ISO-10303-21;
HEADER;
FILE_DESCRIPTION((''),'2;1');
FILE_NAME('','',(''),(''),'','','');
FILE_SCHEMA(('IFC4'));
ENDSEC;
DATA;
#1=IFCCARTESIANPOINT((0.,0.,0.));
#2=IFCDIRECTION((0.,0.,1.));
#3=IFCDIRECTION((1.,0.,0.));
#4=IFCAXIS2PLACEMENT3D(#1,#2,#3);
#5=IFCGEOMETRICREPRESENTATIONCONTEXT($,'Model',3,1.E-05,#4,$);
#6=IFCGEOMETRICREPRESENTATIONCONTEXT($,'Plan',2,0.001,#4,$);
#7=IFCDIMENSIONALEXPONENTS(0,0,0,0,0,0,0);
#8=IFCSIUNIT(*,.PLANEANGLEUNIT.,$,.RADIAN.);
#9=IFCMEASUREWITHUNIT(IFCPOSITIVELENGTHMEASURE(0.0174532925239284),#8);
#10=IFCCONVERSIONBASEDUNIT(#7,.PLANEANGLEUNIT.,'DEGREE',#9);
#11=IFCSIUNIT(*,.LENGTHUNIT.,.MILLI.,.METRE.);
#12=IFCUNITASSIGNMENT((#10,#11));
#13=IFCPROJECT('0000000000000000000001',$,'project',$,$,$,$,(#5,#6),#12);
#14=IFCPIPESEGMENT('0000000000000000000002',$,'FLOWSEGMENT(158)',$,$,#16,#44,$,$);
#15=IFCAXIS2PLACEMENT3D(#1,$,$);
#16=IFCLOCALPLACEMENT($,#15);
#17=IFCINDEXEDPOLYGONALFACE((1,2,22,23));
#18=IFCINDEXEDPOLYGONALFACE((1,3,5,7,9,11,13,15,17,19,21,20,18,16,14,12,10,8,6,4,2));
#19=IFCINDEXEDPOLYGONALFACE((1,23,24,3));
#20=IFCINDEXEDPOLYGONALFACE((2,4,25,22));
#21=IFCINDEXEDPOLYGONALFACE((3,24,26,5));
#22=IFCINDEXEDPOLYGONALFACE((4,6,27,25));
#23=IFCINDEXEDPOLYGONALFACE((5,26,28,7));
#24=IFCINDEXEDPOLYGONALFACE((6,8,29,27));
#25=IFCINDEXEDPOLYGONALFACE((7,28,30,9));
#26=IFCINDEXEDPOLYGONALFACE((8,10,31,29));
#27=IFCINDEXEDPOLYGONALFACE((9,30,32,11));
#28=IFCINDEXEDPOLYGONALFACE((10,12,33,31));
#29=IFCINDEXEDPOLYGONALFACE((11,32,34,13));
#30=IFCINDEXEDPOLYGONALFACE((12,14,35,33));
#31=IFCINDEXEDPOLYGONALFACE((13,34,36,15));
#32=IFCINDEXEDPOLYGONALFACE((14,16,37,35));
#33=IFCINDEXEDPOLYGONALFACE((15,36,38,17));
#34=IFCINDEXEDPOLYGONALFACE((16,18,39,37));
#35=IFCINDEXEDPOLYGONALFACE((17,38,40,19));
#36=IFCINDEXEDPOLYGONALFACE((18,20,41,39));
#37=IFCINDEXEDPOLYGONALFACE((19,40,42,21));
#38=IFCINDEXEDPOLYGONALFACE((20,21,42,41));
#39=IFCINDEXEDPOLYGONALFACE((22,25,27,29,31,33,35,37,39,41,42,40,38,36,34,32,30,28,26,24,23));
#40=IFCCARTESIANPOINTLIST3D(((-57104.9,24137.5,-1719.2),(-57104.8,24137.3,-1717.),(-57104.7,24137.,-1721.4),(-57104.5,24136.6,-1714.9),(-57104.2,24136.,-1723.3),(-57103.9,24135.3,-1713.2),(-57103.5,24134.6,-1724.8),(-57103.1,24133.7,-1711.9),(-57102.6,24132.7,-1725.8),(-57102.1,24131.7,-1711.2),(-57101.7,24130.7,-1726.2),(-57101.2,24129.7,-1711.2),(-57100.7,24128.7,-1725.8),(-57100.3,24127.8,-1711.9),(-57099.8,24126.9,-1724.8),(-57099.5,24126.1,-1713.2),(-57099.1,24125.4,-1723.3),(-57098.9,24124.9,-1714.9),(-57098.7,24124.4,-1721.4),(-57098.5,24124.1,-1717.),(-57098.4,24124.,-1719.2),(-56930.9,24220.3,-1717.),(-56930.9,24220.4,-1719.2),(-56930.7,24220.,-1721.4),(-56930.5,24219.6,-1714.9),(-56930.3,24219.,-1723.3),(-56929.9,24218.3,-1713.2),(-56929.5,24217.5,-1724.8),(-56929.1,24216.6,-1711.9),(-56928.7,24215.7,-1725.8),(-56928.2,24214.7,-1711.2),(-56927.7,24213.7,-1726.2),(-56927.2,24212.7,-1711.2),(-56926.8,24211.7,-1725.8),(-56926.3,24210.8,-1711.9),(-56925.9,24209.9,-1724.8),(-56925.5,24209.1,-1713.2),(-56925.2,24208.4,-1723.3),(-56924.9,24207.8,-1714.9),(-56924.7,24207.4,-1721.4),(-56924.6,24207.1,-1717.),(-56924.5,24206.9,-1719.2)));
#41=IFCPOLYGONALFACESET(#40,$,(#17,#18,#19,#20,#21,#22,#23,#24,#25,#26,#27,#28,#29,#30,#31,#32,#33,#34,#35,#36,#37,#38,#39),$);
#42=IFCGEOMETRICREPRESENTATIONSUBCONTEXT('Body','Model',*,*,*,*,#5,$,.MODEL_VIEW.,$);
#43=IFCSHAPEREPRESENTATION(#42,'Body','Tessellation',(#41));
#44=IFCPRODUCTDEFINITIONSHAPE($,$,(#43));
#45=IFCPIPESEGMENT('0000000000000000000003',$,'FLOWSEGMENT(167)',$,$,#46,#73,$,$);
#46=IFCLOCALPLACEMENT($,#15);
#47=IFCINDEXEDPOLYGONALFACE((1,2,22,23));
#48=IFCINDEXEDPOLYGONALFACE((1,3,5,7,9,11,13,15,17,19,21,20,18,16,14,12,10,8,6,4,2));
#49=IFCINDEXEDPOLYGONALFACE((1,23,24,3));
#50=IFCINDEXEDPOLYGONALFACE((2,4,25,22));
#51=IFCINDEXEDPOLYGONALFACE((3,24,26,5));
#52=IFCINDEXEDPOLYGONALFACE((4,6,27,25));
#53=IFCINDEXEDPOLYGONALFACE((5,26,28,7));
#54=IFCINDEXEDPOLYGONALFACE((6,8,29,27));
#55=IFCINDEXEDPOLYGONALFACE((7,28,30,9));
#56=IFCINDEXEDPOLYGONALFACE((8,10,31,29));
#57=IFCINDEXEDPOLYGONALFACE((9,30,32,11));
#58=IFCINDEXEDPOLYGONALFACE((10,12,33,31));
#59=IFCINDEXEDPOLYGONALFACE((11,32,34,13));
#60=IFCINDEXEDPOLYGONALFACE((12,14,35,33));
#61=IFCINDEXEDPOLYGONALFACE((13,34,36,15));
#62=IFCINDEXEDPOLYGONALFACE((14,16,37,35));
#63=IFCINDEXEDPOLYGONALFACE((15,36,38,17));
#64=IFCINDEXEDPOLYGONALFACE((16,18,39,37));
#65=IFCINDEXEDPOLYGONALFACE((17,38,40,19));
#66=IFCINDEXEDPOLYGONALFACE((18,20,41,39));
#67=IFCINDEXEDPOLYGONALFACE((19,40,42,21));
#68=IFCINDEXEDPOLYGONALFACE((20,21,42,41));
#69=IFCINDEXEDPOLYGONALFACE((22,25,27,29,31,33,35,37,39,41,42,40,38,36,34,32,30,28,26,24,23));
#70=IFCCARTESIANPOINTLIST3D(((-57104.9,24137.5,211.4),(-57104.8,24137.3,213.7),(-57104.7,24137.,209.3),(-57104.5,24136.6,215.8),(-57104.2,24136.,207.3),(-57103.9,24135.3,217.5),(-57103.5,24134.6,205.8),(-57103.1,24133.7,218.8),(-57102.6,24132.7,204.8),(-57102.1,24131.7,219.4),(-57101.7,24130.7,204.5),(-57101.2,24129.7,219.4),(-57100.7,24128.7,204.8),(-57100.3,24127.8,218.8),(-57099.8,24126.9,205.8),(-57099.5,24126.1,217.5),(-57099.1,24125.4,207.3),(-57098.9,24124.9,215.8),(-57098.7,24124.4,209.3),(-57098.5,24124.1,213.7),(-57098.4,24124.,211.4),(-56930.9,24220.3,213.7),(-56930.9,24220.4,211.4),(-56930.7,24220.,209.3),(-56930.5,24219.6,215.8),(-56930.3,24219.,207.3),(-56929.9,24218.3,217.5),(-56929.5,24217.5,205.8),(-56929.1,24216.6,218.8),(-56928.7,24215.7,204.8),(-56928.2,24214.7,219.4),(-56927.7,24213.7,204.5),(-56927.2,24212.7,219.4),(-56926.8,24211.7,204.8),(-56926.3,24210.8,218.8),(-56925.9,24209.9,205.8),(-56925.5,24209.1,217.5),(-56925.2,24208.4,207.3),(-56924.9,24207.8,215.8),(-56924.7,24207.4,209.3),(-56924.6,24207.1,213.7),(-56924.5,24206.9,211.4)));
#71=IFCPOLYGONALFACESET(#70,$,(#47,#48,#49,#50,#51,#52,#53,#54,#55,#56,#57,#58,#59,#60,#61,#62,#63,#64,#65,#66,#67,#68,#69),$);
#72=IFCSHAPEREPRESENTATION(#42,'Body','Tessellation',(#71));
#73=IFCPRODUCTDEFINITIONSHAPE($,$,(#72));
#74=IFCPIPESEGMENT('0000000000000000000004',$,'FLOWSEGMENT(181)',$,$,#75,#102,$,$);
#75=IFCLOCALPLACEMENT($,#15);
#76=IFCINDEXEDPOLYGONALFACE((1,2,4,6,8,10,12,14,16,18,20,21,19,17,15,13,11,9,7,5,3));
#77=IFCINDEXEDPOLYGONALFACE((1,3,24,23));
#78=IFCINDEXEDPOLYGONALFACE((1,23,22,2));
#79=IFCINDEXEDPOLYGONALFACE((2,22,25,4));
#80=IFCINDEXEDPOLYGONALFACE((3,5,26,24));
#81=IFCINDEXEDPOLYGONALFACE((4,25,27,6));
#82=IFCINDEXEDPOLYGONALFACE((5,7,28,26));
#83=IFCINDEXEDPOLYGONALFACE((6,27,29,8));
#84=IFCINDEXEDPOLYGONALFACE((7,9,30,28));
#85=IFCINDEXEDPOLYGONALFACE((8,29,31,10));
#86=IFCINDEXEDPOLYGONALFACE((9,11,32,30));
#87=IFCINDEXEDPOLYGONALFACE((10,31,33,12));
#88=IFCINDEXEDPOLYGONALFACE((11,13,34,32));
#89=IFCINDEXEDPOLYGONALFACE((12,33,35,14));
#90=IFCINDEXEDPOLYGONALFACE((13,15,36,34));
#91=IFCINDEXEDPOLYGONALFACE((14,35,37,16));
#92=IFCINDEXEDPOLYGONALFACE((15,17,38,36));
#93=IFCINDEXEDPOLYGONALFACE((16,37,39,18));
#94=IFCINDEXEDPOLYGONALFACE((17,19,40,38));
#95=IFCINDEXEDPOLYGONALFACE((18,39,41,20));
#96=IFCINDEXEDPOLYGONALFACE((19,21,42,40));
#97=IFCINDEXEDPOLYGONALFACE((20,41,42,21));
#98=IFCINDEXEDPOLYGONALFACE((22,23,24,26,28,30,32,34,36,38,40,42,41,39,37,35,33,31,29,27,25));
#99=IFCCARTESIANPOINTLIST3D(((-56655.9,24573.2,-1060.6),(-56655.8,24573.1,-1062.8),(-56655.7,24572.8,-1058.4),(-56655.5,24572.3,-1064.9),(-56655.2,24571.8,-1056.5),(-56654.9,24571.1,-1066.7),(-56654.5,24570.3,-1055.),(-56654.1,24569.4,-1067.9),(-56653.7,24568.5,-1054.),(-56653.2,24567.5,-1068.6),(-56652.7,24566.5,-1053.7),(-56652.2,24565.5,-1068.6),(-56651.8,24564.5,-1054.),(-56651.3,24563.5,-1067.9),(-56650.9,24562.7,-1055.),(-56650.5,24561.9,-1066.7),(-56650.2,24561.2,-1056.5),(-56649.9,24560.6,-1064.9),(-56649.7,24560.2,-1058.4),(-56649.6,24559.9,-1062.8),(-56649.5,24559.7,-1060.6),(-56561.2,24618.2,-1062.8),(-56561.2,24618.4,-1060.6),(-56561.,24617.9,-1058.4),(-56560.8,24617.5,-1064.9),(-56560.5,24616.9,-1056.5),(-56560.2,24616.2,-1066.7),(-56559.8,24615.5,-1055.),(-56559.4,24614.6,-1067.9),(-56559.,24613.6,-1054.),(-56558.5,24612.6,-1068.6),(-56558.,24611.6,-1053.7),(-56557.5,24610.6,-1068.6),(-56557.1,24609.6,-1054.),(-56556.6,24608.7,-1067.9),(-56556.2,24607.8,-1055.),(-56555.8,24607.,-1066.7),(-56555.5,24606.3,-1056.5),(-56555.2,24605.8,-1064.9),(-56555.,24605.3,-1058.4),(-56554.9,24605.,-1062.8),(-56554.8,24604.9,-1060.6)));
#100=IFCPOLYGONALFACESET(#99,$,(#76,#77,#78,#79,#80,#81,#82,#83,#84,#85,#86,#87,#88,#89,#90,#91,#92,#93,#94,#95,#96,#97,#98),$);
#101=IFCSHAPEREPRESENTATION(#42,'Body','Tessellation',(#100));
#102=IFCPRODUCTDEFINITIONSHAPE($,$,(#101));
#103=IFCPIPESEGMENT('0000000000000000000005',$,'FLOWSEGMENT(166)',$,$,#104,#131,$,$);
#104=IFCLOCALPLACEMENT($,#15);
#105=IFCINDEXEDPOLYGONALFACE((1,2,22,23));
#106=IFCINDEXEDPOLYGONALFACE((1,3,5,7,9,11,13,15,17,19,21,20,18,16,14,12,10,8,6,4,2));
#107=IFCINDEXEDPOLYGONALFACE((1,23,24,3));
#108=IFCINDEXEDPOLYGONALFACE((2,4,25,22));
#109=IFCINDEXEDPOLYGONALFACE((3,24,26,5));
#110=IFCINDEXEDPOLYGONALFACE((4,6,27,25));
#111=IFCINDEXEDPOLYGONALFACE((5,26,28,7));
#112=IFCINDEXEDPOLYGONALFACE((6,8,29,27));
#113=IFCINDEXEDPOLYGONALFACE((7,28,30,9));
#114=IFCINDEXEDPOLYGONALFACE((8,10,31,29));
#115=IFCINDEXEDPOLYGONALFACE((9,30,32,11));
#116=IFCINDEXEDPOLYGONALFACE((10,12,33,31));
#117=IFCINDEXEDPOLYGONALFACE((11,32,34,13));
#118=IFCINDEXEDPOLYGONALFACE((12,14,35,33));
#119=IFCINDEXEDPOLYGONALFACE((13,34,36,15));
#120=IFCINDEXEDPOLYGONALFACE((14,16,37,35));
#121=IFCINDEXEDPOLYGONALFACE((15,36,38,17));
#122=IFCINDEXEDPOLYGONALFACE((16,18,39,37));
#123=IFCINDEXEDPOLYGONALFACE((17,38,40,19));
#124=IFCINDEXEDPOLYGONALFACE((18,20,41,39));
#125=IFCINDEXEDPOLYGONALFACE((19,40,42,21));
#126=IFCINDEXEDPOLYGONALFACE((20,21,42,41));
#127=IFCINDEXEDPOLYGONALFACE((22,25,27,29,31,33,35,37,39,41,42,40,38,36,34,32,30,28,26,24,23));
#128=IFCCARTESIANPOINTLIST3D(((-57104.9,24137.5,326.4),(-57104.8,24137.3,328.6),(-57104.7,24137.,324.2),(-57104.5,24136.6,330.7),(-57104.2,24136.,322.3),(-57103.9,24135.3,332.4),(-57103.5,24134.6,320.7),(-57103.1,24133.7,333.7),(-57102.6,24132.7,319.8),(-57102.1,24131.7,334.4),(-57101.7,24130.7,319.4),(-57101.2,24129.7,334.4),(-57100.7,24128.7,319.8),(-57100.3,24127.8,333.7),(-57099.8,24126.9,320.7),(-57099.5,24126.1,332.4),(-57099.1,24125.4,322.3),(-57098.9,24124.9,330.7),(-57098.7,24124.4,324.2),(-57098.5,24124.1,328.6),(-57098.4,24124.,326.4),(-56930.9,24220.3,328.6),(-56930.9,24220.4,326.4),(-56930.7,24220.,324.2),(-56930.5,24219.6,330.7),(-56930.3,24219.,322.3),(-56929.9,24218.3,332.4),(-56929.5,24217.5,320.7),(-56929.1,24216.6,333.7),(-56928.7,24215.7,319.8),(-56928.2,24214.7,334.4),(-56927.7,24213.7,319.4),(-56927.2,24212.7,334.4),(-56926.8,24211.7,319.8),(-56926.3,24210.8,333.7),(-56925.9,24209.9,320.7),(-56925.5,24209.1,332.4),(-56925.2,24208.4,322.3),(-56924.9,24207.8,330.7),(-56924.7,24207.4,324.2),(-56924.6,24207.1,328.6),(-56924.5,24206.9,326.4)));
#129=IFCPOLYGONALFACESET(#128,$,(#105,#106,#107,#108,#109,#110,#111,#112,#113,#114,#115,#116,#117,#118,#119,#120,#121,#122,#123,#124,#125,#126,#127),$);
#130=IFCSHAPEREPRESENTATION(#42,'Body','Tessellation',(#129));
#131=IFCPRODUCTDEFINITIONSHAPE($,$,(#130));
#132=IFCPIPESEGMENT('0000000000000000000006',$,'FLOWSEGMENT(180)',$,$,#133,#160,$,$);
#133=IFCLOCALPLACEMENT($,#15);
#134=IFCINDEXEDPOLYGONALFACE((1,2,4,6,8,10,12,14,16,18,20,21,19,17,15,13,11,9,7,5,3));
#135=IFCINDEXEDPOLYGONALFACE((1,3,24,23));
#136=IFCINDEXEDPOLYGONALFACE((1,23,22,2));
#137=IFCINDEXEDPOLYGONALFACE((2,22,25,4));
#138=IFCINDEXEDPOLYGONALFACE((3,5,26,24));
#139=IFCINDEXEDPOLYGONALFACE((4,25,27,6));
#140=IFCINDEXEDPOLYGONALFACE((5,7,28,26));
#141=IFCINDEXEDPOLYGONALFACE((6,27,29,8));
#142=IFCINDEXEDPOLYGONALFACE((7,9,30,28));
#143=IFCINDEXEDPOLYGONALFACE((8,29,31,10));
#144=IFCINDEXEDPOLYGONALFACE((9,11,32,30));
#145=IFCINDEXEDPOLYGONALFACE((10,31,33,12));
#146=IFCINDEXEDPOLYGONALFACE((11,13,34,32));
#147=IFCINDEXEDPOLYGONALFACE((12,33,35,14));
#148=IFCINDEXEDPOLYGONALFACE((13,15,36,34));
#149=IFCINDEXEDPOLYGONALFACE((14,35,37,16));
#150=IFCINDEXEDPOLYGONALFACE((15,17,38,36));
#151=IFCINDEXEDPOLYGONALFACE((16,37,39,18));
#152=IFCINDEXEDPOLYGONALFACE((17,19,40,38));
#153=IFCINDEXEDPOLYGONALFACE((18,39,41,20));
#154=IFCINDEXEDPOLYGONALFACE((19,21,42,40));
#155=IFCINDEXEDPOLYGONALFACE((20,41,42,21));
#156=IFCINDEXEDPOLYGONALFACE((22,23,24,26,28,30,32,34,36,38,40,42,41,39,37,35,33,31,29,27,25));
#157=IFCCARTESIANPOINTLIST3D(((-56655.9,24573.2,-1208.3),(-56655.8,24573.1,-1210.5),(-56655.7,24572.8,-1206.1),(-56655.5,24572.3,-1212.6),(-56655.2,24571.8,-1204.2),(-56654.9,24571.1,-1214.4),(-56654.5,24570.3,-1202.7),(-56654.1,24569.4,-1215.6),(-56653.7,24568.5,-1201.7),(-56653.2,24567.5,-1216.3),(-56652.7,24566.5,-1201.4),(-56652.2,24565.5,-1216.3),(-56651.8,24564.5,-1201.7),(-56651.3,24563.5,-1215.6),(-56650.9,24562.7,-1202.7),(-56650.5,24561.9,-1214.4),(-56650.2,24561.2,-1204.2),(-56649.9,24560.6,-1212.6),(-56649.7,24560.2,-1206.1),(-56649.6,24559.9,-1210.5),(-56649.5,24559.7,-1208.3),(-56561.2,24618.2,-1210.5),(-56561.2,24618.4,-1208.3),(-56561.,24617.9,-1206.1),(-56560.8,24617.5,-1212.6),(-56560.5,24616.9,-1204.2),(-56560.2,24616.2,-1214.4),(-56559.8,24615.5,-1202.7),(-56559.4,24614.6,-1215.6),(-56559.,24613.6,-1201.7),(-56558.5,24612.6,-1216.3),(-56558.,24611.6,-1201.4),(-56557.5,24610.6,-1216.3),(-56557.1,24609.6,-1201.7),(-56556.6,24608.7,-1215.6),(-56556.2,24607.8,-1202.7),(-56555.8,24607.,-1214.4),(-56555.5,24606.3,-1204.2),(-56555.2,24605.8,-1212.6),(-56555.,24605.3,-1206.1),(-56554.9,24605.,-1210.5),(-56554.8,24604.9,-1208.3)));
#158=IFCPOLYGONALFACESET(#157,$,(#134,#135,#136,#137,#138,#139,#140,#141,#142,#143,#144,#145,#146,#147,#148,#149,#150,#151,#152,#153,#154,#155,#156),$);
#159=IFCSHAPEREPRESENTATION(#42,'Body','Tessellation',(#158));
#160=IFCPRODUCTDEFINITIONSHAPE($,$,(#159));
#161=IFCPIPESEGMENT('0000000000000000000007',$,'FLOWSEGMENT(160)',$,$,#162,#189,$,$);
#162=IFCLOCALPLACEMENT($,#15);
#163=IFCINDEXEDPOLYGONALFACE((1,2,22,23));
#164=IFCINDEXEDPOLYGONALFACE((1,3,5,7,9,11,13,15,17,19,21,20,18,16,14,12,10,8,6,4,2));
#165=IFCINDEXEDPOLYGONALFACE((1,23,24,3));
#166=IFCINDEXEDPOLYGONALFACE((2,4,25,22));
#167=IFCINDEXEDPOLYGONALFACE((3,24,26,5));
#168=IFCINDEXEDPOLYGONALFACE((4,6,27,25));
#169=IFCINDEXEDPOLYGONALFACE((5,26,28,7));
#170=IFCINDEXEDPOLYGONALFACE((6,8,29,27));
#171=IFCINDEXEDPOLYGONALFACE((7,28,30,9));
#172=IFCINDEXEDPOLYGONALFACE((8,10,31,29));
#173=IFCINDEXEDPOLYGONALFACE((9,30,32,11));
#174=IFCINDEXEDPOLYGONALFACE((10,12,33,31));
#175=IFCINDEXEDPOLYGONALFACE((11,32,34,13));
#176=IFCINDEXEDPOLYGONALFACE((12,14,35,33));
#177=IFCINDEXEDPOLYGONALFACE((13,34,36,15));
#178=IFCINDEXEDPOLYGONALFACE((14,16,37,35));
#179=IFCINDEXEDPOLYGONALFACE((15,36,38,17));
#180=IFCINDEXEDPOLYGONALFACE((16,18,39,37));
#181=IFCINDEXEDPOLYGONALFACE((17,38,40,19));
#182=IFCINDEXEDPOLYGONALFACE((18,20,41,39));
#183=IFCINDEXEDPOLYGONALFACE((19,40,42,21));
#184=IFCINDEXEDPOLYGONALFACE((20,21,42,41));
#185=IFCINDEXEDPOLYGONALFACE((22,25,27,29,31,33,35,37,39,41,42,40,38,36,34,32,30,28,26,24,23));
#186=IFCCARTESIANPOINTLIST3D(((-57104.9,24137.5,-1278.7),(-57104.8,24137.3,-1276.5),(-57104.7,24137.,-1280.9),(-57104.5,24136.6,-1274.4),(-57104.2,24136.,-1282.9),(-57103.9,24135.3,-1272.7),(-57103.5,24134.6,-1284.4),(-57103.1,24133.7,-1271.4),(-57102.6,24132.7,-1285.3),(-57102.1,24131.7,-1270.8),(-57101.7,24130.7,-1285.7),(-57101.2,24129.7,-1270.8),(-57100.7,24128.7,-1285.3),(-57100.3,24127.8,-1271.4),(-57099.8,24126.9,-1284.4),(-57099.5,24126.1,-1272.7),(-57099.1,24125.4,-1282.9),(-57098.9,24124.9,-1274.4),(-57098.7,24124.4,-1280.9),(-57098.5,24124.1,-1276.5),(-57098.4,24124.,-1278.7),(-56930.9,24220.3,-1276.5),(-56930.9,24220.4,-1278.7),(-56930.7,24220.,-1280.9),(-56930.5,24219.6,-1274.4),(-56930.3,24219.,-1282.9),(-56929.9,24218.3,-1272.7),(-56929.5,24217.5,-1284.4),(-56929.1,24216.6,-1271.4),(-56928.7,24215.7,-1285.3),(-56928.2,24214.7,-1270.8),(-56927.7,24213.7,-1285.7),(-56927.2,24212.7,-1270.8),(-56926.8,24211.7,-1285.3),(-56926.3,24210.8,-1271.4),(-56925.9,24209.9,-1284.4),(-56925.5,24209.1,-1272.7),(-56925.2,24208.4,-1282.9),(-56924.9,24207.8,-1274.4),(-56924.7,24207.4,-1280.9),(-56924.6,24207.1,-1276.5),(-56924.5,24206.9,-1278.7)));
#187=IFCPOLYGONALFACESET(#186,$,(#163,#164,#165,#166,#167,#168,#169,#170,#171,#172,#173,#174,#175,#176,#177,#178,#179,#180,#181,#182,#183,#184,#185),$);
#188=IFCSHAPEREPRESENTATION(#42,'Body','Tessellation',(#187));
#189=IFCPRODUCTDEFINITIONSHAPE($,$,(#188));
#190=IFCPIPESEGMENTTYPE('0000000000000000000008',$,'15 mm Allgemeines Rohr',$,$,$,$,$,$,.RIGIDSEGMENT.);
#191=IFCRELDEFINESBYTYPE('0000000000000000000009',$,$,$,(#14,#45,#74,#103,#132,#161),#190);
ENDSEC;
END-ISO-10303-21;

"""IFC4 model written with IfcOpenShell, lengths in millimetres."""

from ifc_helpers import new_model, entity, si_unit, converted_unit, frame, frame_2d, origin, origin_with_axes, place, context, subcontext, project, circle, extrude, source, transform, mapped, type_object, element, save


model = new_model("IFC4")

# Units and contexts
model_context = context("Model", 3, precision=1e-05, world=origin_with_axes())
plan_context = context("Plan", 2, precision=0.001, world=origin_with_axes())
body_context = subcontext(model_context, "Body", "Model", "MODEL_VIEW")
ifc_project = project(units=[converted_unit("PLANEANGLEUNIT", "DEGREE", entity("IfcPositiveLengthMeasure", 0.0174532925239284), si_unit("PLANEANGLEUNIT", "RADIAN"), dimensions=[0, 0, 0, 0, 0, 0, 0]), si_unit("LENGTHUNIT", "METRE", prefix="MILLI")], contexts=[model_context, plan_context])

# Pipe segments
pipe_segment_type = type_object("IfcPipeSegmentType", Name="15 mm Allgemeines Rohr", PredefinedType="RIGIDSEGMENT")
shared_shape = source(origin(), body_context, "Body", "SweptSolid", [
    extrude(circle(Radius=7.5, at=frame_2d((7.5, 7.5), x_axis=(1.0, 0.0))), frame((0.0, -7.5, -7.5), z_axis=(1.0, 0.0, 0.0), x_axis=(0.0, 1.0, 0.0)), (0.0, 0.0, 1.0), 1.0),
])
placement_1 = place(None, origin_with_axes())
placement_2 = place(placement_1, origin_with_axes())
placement_3 = place(placement_2, frame((0.0, 0.0, -3400.0), z_axis=(0.0, 0.0, 1.0), x_axis=(1.0, 0.0, 0.0)))
pipe_segment_1_placement = place(placement_3, frame((-57101.7, 24130.7, 1681.3), z_axis=(-0.430461, 0.902609, 0.0), x_axis=(0.902609, 0.430461, 0.0)))
element("IfcPipeSegment", 1, at=pipe_segment_1_placement, type_object=pipe_segment_type, Name="FLOWSEGMENT(158)", context=body_context, shape_type="MappedRepresentation", body=[
    mapped(shared_shape, transform((0.0, 0.0, 0.0), x_axis=(1.0, 0.0, 0.0), y_axis=(0.0, 1.0, 0.0), z_axis=(0.0, 0.0, 1.0), scale=192.697716, scale2=1.0, scale3=1.0, uniform=False)),
])
pipe_segment_2_placement = place(placement_3, frame((-57101.7, 24130.7, 3612.0), z_axis=(-0.430461, 0.902609, 0.0), x_axis=(0.902609, 0.430461, 0.0)))
element("IfcPipeSegment", 2, at=pipe_segment_2_placement, type_object=pipe_segment_type, Name="FLOWSEGMENT(167)", context=body_context, shape_type="MappedRepresentation", body=[
    mapped(shared_shape, transform((0.0, 0.0, 0.0), x_axis=(1.0, 0.0, 0.0), y_axis=(0.0, 1.0, 0.0), z_axis=(0.0, 0.0, 1.0), scale=192.697716, scale2=1.0, scale3=1.0, uniform=False)),
])
pipe_segment_3_placement = place(placement_3, frame((-56558.0, 24611.6, 2338.8), z_axis=(-0.430461, 0.902609, 0.0), x_axis=(-0.902609, -0.430461, 0.0)))
element("IfcPipeSegment", 3, at=pipe_segment_3_placement, type_object=pipe_segment_type, Name="FLOWSEGMENT(181)", context=body_context, shape_type="MappedRepresentation", body=[
    mapped(shared_shape, transform((0.0, 0.0, 0.0), x_axis=(1.0, 0.0, 0.0), y_axis=(0.0, 1.0, 0.0), z_axis=(0.0, 0.0, 1.0), scale=104.898581, scale2=1.0, scale3=1.0, uniform=False)),
])
pipe_segment_4_placement = place(placement_3, frame((-57101.7, 24130.7, 3726.9), z_axis=(-0.430461, 0.902609, 0.0), x_axis=(0.902609, 0.430461, 0.0)))
element("IfcPipeSegment", 4, at=pipe_segment_4_placement, type_object=pipe_segment_type, Name="FLOWSEGMENT(166)", context=body_context, shape_type="MappedRepresentation", body=[
    mapped(shared_shape, transform((0.0, 0.0, 0.0), x_axis=(1.0, 0.0, 0.0), y_axis=(0.0, 1.0, 0.0), z_axis=(0.0, 0.0, 1.0), scale=192.697716, scale2=1.0, scale3=1.0, uniform=False)),
])
pipe_segment_5_placement = place(placement_3, frame((-56558.0, 24611.6, 2191.1), z_axis=(-0.430461, 0.902609, 0.0), x_axis=(-0.902609, -0.430461, 0.0)))
element("IfcPipeSegment", 5, at=pipe_segment_5_placement, type_object=pipe_segment_type, Name="FLOWSEGMENT(180)", context=body_context, shape_type="MappedRepresentation", body=[
    mapped(shared_shape, transform((0.0, 0.0, 0.0), x_axis=(1.0, 0.0, 0.0), y_axis=(0.0, 1.0, 0.0), z_axis=(0.0, 0.0, 1.0), scale=104.898581, scale2=1.0, scale3=1.0, uniform=False)),
])
pipe_segment_6_placement = place(placement_3, frame((-57101.7, 24130.7, 2121.8), z_axis=(-0.430461, 0.902609, 0.0), x_axis=(0.902609, 0.430461, 0.0)))
element("IfcPipeSegment", 6, at=pipe_segment_6_placement, type_object=pipe_segment_type, Name="FLOWSEGMENT(160)", context=body_context, shape_type="MappedRepresentation", body=[
    mapped(shared_shape, transform((0.0, 0.0, 0.0), x_axis=(1.0, 0.0, 0.0), y_axis=(0.0, 1.0, 0.0), z_axis=(0.0, 0.0, 1.0), scale=192.697716, scale2=1.0, scale3=1.0, uniform=False)),
])

save(model, "model.ifc")
